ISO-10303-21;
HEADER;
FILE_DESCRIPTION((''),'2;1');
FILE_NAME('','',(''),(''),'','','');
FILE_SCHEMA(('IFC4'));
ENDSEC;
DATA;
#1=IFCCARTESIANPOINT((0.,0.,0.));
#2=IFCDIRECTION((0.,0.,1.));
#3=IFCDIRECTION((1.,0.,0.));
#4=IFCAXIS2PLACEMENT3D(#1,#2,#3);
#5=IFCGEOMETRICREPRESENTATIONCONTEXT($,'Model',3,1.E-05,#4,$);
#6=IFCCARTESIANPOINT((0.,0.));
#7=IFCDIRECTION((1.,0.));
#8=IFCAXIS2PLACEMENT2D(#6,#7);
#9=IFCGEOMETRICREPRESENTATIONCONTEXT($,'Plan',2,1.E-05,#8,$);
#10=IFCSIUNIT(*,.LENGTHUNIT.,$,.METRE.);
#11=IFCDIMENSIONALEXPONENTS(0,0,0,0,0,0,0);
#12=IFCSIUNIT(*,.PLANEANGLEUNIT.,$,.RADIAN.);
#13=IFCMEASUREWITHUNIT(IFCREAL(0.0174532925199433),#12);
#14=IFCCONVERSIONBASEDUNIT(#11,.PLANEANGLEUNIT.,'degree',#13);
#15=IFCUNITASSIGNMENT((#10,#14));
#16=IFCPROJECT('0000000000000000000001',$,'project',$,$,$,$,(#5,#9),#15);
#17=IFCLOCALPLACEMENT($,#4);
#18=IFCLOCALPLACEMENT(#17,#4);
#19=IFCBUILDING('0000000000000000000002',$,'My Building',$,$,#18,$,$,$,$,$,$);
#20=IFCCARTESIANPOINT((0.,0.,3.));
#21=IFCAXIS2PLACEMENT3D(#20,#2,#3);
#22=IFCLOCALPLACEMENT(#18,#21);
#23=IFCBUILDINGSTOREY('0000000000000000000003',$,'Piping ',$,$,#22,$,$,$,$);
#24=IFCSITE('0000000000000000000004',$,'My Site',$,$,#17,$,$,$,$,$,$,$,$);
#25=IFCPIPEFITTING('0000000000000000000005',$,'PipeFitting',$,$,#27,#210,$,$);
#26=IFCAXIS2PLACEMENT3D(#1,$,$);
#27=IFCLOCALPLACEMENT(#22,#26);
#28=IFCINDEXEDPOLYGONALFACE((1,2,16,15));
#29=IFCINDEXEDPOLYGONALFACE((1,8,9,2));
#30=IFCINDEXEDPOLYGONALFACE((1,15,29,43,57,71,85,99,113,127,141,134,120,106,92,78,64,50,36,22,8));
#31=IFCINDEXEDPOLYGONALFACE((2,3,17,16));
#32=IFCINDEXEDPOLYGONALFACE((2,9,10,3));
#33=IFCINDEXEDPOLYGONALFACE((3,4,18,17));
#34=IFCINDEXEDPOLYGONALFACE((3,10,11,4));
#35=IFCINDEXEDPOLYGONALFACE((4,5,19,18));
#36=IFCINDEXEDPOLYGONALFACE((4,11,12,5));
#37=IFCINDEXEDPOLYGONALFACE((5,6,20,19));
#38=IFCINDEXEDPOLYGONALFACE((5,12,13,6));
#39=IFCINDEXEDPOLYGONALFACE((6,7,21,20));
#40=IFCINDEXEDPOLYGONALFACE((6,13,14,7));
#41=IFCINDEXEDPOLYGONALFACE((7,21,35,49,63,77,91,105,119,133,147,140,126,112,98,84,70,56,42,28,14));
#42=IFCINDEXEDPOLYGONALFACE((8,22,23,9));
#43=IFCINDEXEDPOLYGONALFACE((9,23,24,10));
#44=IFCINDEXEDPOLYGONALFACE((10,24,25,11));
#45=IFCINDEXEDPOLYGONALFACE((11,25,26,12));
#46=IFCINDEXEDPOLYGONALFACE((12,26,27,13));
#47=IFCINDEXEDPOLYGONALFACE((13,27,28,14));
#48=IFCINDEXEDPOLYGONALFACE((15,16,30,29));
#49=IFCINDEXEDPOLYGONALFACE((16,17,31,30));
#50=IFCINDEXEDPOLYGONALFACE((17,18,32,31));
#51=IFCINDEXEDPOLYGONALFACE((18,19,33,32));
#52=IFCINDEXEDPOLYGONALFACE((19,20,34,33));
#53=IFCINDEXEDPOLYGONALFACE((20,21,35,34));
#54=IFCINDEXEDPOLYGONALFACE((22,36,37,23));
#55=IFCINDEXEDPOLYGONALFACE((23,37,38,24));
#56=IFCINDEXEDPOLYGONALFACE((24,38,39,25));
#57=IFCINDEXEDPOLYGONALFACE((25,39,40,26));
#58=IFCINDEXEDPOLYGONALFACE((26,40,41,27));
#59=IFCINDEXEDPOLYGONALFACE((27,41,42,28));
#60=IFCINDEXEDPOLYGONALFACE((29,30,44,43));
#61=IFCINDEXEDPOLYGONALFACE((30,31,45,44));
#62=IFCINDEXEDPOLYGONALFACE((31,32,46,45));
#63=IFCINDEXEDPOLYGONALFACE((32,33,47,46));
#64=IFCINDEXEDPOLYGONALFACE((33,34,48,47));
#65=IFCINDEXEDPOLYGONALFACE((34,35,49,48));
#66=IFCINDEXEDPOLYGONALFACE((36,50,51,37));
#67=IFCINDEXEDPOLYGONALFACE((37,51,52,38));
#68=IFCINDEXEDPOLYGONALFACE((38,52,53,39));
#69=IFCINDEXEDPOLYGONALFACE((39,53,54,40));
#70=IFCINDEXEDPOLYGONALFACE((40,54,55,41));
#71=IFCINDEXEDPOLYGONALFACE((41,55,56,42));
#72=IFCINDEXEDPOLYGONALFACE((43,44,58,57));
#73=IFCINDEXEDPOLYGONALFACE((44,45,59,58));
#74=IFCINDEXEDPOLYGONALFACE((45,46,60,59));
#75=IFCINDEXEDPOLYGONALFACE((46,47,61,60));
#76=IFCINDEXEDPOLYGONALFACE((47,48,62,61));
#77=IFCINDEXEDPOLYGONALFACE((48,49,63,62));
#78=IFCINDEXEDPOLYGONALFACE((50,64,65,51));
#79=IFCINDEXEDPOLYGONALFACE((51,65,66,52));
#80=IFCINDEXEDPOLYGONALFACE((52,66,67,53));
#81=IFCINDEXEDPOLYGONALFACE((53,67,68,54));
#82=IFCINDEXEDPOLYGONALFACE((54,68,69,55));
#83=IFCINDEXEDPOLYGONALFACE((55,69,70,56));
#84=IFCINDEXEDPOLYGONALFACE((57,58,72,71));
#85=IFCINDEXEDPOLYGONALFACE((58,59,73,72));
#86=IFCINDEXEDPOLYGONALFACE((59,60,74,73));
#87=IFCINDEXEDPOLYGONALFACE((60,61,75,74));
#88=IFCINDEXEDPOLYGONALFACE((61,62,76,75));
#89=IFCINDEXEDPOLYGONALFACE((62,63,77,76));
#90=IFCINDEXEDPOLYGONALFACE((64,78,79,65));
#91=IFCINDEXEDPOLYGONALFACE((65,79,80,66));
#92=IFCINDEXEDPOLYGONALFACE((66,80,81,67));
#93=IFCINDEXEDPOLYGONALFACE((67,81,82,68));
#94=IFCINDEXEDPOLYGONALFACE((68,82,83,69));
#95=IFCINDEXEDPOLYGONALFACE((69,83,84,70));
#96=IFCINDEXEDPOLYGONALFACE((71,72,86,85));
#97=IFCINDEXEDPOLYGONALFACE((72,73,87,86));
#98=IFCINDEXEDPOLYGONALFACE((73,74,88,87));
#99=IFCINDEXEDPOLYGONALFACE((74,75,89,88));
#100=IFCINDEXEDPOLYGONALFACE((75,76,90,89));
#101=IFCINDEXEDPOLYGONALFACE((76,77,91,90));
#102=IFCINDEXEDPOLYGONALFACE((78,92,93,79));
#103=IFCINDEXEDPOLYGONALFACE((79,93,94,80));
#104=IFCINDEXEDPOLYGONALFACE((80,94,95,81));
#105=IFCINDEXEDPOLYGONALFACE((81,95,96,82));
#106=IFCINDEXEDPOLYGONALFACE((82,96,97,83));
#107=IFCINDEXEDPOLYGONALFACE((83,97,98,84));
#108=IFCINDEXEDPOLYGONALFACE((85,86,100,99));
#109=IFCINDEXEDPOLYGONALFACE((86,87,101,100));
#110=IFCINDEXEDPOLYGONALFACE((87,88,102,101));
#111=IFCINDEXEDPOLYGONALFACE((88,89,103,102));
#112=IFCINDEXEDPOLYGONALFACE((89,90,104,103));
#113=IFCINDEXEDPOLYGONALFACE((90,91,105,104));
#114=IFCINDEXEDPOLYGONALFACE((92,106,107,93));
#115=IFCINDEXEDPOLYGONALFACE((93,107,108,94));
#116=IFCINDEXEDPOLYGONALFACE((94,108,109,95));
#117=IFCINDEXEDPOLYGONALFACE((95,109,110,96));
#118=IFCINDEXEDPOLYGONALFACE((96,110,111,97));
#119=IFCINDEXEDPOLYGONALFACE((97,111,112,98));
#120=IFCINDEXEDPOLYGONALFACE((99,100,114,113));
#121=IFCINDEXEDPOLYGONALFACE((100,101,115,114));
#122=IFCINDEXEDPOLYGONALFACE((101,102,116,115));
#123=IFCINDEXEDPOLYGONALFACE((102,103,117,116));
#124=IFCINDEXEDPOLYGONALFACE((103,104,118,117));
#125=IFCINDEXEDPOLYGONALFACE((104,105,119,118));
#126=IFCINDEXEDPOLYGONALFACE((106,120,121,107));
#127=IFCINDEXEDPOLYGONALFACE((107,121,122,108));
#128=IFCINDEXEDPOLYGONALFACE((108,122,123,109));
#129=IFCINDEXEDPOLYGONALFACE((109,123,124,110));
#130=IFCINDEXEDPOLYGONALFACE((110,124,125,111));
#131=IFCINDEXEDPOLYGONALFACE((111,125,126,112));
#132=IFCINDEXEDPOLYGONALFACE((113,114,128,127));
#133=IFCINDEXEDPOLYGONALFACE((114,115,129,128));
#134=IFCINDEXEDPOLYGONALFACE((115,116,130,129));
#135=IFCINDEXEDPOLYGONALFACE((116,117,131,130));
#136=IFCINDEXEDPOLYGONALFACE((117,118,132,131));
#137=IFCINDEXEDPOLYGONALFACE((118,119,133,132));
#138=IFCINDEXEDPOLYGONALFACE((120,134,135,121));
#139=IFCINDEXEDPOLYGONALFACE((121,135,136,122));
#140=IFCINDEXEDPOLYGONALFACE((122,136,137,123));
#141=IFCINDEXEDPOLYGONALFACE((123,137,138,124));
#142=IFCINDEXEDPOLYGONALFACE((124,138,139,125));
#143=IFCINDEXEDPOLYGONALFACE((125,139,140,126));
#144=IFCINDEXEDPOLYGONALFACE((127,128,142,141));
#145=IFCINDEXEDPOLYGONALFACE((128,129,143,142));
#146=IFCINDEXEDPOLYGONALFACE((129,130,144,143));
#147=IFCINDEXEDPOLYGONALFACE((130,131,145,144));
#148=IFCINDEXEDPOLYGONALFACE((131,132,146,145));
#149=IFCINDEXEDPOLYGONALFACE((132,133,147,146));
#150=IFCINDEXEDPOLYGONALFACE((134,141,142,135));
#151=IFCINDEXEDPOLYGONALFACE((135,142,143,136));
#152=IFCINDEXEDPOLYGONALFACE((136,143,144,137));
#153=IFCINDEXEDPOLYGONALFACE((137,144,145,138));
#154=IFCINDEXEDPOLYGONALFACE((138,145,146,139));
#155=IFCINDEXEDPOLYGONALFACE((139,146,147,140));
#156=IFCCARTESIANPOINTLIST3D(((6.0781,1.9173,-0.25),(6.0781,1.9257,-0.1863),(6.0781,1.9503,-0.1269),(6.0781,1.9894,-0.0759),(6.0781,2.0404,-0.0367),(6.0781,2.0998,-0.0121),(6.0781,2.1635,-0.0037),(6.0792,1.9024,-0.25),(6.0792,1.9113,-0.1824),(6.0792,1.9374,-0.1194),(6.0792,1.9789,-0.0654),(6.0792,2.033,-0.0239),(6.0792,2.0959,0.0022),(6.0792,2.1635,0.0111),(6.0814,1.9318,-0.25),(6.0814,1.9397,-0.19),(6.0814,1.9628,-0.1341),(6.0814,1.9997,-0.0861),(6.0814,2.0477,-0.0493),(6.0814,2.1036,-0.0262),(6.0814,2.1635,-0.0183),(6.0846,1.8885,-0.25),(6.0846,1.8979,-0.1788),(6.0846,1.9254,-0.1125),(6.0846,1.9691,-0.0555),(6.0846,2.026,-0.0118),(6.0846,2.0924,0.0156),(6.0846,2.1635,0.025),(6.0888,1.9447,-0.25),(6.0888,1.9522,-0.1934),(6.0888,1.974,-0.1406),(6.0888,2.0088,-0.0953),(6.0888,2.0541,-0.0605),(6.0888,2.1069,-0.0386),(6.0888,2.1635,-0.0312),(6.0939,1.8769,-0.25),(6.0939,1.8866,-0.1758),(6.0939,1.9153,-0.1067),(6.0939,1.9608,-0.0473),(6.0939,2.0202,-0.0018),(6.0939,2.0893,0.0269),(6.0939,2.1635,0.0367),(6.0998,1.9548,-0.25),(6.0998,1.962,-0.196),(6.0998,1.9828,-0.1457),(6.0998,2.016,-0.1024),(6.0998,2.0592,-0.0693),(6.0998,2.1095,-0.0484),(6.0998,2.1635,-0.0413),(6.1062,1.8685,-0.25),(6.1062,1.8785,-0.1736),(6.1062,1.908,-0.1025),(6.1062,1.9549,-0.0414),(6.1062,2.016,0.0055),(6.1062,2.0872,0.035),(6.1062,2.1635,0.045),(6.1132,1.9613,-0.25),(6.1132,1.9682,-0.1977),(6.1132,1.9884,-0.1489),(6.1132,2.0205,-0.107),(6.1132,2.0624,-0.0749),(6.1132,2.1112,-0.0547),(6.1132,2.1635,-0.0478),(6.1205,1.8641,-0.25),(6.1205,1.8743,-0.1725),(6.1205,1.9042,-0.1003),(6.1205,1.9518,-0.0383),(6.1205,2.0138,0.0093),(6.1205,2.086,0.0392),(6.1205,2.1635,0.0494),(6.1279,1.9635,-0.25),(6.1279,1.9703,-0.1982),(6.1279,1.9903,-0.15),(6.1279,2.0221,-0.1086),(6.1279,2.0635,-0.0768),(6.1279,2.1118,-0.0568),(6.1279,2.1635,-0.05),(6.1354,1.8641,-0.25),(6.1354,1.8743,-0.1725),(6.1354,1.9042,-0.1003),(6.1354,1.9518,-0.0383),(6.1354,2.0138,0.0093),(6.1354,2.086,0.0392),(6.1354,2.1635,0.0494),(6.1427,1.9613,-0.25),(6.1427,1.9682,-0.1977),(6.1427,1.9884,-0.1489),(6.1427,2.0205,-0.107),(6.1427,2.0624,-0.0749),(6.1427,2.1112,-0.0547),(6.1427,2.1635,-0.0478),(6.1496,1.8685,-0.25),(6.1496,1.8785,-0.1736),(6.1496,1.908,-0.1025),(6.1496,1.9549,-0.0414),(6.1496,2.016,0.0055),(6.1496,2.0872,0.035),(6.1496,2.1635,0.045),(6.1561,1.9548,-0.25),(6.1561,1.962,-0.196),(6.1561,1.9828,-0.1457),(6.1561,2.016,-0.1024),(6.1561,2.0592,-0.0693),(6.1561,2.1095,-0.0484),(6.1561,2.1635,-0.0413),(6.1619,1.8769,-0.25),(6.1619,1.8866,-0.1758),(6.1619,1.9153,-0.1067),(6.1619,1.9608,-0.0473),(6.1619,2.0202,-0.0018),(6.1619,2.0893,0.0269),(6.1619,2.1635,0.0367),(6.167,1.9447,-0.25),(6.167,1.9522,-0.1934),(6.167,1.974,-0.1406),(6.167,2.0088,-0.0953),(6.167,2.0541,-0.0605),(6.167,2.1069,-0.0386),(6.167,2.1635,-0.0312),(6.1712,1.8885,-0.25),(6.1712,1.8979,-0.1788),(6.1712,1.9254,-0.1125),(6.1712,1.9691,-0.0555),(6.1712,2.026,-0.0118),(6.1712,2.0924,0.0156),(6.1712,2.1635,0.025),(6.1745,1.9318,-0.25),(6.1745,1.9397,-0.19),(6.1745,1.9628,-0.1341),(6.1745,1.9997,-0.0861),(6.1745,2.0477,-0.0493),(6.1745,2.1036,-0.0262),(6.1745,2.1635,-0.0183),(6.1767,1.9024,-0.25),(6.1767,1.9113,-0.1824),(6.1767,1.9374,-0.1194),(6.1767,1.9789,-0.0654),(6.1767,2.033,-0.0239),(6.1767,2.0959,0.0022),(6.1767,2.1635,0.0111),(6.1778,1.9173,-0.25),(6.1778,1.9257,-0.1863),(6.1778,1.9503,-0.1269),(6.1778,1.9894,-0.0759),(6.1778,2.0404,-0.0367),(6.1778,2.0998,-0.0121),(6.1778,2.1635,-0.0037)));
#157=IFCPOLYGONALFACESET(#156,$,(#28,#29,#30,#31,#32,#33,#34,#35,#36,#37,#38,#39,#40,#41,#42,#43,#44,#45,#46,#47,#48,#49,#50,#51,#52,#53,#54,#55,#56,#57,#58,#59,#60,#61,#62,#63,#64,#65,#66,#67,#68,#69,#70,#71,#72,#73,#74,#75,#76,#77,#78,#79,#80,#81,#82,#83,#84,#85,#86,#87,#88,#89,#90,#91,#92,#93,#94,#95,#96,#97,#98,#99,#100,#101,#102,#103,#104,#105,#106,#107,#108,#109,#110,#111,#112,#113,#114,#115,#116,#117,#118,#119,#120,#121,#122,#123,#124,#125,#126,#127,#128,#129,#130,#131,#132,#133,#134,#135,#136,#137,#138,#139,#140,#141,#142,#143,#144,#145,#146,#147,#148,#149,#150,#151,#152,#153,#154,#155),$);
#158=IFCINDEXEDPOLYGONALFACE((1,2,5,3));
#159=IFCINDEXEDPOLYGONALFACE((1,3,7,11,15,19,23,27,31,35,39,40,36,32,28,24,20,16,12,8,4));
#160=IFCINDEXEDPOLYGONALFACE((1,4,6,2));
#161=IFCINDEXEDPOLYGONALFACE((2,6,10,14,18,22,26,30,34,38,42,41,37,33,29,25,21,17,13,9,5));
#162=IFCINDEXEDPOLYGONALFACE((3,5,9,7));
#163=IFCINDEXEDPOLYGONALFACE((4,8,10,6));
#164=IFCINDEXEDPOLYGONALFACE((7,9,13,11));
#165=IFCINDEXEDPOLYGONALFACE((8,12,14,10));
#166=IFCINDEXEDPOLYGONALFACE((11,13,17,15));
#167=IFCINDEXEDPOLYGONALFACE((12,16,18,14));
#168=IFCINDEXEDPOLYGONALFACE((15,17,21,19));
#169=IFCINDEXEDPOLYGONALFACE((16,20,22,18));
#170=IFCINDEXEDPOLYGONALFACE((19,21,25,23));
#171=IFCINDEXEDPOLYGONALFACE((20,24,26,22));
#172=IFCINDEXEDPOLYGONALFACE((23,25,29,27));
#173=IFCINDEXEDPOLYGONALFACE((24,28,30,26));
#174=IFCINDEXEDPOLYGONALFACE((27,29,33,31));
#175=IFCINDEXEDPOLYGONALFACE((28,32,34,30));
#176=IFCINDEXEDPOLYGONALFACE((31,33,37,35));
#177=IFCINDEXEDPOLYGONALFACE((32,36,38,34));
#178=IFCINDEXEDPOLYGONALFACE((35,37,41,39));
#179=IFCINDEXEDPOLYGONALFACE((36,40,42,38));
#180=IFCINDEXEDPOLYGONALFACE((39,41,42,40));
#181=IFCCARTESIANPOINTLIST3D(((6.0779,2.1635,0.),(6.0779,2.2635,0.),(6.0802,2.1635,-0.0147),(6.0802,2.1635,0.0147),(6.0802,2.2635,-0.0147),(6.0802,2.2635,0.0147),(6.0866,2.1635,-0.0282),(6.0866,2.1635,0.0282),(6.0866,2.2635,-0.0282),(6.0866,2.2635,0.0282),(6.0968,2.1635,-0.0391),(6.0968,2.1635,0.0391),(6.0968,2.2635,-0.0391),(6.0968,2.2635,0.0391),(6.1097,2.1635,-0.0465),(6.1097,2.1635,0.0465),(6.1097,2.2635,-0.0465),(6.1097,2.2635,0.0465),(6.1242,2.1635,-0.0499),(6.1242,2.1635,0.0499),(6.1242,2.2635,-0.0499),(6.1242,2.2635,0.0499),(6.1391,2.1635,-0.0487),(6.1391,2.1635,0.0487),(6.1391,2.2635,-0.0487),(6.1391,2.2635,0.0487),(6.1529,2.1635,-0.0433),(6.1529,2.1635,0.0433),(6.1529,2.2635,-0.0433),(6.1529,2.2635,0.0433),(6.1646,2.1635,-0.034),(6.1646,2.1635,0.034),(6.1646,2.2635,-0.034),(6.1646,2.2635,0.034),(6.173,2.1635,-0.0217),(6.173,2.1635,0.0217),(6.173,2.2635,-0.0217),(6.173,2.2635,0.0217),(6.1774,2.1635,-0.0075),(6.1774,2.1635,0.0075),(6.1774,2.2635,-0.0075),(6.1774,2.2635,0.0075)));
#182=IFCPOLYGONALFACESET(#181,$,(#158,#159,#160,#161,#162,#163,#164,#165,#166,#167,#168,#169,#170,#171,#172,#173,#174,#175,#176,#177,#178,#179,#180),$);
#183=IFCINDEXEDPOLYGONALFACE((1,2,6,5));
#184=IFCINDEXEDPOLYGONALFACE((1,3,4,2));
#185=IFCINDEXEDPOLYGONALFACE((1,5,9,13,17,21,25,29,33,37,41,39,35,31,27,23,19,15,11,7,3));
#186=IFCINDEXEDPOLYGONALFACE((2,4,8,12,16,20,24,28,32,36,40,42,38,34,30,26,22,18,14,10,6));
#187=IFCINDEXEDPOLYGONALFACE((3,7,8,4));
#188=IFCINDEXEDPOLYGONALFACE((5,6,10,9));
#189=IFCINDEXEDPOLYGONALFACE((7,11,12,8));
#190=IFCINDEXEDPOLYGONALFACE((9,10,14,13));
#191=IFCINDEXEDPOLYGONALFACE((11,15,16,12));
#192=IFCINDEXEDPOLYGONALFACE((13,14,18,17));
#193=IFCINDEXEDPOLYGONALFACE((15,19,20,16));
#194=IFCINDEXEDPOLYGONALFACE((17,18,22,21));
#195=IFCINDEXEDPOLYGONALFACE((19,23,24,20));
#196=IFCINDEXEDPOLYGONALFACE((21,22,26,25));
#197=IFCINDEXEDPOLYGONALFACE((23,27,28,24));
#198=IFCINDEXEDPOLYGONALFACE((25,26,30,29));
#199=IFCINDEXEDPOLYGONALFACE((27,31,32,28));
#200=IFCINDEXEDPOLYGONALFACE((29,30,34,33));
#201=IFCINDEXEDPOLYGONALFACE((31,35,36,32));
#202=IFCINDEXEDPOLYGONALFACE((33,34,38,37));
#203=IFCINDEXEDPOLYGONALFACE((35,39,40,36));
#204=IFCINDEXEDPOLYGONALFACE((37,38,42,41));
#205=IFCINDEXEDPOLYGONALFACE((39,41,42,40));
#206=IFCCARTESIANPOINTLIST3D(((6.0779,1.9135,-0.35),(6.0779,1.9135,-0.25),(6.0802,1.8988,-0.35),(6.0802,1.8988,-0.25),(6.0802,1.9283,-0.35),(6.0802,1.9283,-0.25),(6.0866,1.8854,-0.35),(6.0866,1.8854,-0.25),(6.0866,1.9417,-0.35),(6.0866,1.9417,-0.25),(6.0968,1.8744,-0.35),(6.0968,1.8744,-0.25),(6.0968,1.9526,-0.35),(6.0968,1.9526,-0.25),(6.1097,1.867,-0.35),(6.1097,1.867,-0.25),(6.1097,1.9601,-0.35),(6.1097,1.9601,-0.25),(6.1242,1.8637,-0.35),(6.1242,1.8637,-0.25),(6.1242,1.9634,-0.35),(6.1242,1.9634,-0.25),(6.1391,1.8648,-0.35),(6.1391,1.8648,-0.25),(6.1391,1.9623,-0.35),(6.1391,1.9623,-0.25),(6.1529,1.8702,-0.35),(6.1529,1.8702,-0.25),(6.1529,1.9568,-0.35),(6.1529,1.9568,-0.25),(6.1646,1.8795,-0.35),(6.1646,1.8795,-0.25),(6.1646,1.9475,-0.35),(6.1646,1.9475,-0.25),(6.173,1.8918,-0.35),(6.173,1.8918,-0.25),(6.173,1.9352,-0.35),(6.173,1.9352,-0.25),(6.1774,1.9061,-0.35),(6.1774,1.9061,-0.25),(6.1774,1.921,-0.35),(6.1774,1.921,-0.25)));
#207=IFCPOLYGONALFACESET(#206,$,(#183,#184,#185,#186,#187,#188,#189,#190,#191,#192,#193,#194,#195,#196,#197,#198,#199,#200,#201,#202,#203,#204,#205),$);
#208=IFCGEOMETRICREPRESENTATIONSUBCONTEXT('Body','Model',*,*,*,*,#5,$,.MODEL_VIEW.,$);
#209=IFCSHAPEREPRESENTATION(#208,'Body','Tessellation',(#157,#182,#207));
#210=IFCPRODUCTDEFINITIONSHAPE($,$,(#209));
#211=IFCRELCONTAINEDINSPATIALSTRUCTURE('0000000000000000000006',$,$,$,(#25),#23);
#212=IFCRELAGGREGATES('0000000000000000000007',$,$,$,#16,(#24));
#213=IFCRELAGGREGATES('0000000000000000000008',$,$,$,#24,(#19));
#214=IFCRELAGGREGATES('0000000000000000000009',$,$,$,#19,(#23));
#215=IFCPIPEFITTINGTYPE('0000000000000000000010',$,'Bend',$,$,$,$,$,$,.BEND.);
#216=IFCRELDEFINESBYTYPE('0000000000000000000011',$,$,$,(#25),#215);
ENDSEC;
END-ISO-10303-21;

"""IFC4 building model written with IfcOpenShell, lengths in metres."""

from ifc_helpers import new_model, entity, si_unit, converted_unit, frame, origin_with_axes, origin_2d_with_axis, place, context, subcontext, project, spatial, circle, extrude, source, transform, mapped, type_object, type_shapes, element, save


model = new_model("IFC4")

# Units and contexts
model_context = context("Model", 3, precision=1e-05, world=origin_with_axes())
plan_context = context("Plan", 2, precision=1e-05, world=origin_2d_with_axis())
body_context = subcontext(model_context, "Body", "Model", "MODEL_VIEW")
ifc_project = project(units=[si_unit("LENGTHUNIT", "METRE"), converted_unit("PLANEANGLEUNIT", "degree", entity("IfcReal", 0.0174532925199433), si_unit("PLANEANGLEUNIT", "RADIAN"), dimensions=[0, 0, 0, 0, 0, 0, 0])], contexts=[model_context, plan_context])

# Site, building, storey
site_placement = place(None, origin_with_axes())
site = spatial("IfcSite", under=ifc_project, at=site_placement, Name="My Site")
building_placement = place(site_placement, origin_with_axes())
building = spatial("IfcBuilding", under=site, at=building_placement, Name="My Building")
storey_placement = place(building_placement, frame((0.0, 0.0, 3.0), z_axis=(0.0, 0.0, 1.0), x_axis=(1.0, 0.0, 0.0)))
storey = spatial("IfcBuildingStorey", under=building, at=storey_placement, Name="Piping ")

# Pipe fitting
pipe_fitting_type = type_object("IfcPipeFittingType", Name="Bend", PredefinedType="BEND")
shared_shape = source(origin_with_axes(), body_context, "Body", "SolidModel", [
    entity("IfcSweptDiskSolid", entity("IfcIndexedPolyCurve", entity("IfcCartesianPointList3D", [[0.0, 0.0, -0.1], [0.0, -0.0732, -0.2768], [0.0, -0.25, -0.35]]), [entity("IfcArcIndex", [1, 2, 3])]), 0.05),
    extrude(circle(Radius=0.05), origin_with_axes(), (0.0, 0.0, -1.0), 0.1),
    extrude(circle(Radius=0.05), frame((0.0, -0.25, -0.35), z_axis=(0.0, -1.0, 0.0), x_axis=(1.0, 0.0, 0.0)), (0.0, 0.0, 1.0), 0.1),
])
type_shapes(pipe_fitting_type, [shared_shape])
for number, where, z_axis, x_axis, name in (
    (1, (6.1279, 2.2635, 0.0), (0.0, 1.0, 0.0), (-1.0, 0.0, 0.0), "PipeFitting"),
):
    element("IfcPipeFitting", number, at=place(storey_placement, frame(where, z_axis=z_axis, x_axis=x_axis)), inside=storey, type_object=pipe_fitting_type, Name=name, context=body_context, shape_type="MappedRepresentation", body=[
        mapped(shared_shape, transform((0.0, 0.0, 0.0), x_axis=(1.0, 0.0, 0.0), y_axis=(0.0, 1.0, 0.0), z_axis=(0.0, 0.0, 1.0), scale=1.0)),
    ])

save(model, "model.ifc")
